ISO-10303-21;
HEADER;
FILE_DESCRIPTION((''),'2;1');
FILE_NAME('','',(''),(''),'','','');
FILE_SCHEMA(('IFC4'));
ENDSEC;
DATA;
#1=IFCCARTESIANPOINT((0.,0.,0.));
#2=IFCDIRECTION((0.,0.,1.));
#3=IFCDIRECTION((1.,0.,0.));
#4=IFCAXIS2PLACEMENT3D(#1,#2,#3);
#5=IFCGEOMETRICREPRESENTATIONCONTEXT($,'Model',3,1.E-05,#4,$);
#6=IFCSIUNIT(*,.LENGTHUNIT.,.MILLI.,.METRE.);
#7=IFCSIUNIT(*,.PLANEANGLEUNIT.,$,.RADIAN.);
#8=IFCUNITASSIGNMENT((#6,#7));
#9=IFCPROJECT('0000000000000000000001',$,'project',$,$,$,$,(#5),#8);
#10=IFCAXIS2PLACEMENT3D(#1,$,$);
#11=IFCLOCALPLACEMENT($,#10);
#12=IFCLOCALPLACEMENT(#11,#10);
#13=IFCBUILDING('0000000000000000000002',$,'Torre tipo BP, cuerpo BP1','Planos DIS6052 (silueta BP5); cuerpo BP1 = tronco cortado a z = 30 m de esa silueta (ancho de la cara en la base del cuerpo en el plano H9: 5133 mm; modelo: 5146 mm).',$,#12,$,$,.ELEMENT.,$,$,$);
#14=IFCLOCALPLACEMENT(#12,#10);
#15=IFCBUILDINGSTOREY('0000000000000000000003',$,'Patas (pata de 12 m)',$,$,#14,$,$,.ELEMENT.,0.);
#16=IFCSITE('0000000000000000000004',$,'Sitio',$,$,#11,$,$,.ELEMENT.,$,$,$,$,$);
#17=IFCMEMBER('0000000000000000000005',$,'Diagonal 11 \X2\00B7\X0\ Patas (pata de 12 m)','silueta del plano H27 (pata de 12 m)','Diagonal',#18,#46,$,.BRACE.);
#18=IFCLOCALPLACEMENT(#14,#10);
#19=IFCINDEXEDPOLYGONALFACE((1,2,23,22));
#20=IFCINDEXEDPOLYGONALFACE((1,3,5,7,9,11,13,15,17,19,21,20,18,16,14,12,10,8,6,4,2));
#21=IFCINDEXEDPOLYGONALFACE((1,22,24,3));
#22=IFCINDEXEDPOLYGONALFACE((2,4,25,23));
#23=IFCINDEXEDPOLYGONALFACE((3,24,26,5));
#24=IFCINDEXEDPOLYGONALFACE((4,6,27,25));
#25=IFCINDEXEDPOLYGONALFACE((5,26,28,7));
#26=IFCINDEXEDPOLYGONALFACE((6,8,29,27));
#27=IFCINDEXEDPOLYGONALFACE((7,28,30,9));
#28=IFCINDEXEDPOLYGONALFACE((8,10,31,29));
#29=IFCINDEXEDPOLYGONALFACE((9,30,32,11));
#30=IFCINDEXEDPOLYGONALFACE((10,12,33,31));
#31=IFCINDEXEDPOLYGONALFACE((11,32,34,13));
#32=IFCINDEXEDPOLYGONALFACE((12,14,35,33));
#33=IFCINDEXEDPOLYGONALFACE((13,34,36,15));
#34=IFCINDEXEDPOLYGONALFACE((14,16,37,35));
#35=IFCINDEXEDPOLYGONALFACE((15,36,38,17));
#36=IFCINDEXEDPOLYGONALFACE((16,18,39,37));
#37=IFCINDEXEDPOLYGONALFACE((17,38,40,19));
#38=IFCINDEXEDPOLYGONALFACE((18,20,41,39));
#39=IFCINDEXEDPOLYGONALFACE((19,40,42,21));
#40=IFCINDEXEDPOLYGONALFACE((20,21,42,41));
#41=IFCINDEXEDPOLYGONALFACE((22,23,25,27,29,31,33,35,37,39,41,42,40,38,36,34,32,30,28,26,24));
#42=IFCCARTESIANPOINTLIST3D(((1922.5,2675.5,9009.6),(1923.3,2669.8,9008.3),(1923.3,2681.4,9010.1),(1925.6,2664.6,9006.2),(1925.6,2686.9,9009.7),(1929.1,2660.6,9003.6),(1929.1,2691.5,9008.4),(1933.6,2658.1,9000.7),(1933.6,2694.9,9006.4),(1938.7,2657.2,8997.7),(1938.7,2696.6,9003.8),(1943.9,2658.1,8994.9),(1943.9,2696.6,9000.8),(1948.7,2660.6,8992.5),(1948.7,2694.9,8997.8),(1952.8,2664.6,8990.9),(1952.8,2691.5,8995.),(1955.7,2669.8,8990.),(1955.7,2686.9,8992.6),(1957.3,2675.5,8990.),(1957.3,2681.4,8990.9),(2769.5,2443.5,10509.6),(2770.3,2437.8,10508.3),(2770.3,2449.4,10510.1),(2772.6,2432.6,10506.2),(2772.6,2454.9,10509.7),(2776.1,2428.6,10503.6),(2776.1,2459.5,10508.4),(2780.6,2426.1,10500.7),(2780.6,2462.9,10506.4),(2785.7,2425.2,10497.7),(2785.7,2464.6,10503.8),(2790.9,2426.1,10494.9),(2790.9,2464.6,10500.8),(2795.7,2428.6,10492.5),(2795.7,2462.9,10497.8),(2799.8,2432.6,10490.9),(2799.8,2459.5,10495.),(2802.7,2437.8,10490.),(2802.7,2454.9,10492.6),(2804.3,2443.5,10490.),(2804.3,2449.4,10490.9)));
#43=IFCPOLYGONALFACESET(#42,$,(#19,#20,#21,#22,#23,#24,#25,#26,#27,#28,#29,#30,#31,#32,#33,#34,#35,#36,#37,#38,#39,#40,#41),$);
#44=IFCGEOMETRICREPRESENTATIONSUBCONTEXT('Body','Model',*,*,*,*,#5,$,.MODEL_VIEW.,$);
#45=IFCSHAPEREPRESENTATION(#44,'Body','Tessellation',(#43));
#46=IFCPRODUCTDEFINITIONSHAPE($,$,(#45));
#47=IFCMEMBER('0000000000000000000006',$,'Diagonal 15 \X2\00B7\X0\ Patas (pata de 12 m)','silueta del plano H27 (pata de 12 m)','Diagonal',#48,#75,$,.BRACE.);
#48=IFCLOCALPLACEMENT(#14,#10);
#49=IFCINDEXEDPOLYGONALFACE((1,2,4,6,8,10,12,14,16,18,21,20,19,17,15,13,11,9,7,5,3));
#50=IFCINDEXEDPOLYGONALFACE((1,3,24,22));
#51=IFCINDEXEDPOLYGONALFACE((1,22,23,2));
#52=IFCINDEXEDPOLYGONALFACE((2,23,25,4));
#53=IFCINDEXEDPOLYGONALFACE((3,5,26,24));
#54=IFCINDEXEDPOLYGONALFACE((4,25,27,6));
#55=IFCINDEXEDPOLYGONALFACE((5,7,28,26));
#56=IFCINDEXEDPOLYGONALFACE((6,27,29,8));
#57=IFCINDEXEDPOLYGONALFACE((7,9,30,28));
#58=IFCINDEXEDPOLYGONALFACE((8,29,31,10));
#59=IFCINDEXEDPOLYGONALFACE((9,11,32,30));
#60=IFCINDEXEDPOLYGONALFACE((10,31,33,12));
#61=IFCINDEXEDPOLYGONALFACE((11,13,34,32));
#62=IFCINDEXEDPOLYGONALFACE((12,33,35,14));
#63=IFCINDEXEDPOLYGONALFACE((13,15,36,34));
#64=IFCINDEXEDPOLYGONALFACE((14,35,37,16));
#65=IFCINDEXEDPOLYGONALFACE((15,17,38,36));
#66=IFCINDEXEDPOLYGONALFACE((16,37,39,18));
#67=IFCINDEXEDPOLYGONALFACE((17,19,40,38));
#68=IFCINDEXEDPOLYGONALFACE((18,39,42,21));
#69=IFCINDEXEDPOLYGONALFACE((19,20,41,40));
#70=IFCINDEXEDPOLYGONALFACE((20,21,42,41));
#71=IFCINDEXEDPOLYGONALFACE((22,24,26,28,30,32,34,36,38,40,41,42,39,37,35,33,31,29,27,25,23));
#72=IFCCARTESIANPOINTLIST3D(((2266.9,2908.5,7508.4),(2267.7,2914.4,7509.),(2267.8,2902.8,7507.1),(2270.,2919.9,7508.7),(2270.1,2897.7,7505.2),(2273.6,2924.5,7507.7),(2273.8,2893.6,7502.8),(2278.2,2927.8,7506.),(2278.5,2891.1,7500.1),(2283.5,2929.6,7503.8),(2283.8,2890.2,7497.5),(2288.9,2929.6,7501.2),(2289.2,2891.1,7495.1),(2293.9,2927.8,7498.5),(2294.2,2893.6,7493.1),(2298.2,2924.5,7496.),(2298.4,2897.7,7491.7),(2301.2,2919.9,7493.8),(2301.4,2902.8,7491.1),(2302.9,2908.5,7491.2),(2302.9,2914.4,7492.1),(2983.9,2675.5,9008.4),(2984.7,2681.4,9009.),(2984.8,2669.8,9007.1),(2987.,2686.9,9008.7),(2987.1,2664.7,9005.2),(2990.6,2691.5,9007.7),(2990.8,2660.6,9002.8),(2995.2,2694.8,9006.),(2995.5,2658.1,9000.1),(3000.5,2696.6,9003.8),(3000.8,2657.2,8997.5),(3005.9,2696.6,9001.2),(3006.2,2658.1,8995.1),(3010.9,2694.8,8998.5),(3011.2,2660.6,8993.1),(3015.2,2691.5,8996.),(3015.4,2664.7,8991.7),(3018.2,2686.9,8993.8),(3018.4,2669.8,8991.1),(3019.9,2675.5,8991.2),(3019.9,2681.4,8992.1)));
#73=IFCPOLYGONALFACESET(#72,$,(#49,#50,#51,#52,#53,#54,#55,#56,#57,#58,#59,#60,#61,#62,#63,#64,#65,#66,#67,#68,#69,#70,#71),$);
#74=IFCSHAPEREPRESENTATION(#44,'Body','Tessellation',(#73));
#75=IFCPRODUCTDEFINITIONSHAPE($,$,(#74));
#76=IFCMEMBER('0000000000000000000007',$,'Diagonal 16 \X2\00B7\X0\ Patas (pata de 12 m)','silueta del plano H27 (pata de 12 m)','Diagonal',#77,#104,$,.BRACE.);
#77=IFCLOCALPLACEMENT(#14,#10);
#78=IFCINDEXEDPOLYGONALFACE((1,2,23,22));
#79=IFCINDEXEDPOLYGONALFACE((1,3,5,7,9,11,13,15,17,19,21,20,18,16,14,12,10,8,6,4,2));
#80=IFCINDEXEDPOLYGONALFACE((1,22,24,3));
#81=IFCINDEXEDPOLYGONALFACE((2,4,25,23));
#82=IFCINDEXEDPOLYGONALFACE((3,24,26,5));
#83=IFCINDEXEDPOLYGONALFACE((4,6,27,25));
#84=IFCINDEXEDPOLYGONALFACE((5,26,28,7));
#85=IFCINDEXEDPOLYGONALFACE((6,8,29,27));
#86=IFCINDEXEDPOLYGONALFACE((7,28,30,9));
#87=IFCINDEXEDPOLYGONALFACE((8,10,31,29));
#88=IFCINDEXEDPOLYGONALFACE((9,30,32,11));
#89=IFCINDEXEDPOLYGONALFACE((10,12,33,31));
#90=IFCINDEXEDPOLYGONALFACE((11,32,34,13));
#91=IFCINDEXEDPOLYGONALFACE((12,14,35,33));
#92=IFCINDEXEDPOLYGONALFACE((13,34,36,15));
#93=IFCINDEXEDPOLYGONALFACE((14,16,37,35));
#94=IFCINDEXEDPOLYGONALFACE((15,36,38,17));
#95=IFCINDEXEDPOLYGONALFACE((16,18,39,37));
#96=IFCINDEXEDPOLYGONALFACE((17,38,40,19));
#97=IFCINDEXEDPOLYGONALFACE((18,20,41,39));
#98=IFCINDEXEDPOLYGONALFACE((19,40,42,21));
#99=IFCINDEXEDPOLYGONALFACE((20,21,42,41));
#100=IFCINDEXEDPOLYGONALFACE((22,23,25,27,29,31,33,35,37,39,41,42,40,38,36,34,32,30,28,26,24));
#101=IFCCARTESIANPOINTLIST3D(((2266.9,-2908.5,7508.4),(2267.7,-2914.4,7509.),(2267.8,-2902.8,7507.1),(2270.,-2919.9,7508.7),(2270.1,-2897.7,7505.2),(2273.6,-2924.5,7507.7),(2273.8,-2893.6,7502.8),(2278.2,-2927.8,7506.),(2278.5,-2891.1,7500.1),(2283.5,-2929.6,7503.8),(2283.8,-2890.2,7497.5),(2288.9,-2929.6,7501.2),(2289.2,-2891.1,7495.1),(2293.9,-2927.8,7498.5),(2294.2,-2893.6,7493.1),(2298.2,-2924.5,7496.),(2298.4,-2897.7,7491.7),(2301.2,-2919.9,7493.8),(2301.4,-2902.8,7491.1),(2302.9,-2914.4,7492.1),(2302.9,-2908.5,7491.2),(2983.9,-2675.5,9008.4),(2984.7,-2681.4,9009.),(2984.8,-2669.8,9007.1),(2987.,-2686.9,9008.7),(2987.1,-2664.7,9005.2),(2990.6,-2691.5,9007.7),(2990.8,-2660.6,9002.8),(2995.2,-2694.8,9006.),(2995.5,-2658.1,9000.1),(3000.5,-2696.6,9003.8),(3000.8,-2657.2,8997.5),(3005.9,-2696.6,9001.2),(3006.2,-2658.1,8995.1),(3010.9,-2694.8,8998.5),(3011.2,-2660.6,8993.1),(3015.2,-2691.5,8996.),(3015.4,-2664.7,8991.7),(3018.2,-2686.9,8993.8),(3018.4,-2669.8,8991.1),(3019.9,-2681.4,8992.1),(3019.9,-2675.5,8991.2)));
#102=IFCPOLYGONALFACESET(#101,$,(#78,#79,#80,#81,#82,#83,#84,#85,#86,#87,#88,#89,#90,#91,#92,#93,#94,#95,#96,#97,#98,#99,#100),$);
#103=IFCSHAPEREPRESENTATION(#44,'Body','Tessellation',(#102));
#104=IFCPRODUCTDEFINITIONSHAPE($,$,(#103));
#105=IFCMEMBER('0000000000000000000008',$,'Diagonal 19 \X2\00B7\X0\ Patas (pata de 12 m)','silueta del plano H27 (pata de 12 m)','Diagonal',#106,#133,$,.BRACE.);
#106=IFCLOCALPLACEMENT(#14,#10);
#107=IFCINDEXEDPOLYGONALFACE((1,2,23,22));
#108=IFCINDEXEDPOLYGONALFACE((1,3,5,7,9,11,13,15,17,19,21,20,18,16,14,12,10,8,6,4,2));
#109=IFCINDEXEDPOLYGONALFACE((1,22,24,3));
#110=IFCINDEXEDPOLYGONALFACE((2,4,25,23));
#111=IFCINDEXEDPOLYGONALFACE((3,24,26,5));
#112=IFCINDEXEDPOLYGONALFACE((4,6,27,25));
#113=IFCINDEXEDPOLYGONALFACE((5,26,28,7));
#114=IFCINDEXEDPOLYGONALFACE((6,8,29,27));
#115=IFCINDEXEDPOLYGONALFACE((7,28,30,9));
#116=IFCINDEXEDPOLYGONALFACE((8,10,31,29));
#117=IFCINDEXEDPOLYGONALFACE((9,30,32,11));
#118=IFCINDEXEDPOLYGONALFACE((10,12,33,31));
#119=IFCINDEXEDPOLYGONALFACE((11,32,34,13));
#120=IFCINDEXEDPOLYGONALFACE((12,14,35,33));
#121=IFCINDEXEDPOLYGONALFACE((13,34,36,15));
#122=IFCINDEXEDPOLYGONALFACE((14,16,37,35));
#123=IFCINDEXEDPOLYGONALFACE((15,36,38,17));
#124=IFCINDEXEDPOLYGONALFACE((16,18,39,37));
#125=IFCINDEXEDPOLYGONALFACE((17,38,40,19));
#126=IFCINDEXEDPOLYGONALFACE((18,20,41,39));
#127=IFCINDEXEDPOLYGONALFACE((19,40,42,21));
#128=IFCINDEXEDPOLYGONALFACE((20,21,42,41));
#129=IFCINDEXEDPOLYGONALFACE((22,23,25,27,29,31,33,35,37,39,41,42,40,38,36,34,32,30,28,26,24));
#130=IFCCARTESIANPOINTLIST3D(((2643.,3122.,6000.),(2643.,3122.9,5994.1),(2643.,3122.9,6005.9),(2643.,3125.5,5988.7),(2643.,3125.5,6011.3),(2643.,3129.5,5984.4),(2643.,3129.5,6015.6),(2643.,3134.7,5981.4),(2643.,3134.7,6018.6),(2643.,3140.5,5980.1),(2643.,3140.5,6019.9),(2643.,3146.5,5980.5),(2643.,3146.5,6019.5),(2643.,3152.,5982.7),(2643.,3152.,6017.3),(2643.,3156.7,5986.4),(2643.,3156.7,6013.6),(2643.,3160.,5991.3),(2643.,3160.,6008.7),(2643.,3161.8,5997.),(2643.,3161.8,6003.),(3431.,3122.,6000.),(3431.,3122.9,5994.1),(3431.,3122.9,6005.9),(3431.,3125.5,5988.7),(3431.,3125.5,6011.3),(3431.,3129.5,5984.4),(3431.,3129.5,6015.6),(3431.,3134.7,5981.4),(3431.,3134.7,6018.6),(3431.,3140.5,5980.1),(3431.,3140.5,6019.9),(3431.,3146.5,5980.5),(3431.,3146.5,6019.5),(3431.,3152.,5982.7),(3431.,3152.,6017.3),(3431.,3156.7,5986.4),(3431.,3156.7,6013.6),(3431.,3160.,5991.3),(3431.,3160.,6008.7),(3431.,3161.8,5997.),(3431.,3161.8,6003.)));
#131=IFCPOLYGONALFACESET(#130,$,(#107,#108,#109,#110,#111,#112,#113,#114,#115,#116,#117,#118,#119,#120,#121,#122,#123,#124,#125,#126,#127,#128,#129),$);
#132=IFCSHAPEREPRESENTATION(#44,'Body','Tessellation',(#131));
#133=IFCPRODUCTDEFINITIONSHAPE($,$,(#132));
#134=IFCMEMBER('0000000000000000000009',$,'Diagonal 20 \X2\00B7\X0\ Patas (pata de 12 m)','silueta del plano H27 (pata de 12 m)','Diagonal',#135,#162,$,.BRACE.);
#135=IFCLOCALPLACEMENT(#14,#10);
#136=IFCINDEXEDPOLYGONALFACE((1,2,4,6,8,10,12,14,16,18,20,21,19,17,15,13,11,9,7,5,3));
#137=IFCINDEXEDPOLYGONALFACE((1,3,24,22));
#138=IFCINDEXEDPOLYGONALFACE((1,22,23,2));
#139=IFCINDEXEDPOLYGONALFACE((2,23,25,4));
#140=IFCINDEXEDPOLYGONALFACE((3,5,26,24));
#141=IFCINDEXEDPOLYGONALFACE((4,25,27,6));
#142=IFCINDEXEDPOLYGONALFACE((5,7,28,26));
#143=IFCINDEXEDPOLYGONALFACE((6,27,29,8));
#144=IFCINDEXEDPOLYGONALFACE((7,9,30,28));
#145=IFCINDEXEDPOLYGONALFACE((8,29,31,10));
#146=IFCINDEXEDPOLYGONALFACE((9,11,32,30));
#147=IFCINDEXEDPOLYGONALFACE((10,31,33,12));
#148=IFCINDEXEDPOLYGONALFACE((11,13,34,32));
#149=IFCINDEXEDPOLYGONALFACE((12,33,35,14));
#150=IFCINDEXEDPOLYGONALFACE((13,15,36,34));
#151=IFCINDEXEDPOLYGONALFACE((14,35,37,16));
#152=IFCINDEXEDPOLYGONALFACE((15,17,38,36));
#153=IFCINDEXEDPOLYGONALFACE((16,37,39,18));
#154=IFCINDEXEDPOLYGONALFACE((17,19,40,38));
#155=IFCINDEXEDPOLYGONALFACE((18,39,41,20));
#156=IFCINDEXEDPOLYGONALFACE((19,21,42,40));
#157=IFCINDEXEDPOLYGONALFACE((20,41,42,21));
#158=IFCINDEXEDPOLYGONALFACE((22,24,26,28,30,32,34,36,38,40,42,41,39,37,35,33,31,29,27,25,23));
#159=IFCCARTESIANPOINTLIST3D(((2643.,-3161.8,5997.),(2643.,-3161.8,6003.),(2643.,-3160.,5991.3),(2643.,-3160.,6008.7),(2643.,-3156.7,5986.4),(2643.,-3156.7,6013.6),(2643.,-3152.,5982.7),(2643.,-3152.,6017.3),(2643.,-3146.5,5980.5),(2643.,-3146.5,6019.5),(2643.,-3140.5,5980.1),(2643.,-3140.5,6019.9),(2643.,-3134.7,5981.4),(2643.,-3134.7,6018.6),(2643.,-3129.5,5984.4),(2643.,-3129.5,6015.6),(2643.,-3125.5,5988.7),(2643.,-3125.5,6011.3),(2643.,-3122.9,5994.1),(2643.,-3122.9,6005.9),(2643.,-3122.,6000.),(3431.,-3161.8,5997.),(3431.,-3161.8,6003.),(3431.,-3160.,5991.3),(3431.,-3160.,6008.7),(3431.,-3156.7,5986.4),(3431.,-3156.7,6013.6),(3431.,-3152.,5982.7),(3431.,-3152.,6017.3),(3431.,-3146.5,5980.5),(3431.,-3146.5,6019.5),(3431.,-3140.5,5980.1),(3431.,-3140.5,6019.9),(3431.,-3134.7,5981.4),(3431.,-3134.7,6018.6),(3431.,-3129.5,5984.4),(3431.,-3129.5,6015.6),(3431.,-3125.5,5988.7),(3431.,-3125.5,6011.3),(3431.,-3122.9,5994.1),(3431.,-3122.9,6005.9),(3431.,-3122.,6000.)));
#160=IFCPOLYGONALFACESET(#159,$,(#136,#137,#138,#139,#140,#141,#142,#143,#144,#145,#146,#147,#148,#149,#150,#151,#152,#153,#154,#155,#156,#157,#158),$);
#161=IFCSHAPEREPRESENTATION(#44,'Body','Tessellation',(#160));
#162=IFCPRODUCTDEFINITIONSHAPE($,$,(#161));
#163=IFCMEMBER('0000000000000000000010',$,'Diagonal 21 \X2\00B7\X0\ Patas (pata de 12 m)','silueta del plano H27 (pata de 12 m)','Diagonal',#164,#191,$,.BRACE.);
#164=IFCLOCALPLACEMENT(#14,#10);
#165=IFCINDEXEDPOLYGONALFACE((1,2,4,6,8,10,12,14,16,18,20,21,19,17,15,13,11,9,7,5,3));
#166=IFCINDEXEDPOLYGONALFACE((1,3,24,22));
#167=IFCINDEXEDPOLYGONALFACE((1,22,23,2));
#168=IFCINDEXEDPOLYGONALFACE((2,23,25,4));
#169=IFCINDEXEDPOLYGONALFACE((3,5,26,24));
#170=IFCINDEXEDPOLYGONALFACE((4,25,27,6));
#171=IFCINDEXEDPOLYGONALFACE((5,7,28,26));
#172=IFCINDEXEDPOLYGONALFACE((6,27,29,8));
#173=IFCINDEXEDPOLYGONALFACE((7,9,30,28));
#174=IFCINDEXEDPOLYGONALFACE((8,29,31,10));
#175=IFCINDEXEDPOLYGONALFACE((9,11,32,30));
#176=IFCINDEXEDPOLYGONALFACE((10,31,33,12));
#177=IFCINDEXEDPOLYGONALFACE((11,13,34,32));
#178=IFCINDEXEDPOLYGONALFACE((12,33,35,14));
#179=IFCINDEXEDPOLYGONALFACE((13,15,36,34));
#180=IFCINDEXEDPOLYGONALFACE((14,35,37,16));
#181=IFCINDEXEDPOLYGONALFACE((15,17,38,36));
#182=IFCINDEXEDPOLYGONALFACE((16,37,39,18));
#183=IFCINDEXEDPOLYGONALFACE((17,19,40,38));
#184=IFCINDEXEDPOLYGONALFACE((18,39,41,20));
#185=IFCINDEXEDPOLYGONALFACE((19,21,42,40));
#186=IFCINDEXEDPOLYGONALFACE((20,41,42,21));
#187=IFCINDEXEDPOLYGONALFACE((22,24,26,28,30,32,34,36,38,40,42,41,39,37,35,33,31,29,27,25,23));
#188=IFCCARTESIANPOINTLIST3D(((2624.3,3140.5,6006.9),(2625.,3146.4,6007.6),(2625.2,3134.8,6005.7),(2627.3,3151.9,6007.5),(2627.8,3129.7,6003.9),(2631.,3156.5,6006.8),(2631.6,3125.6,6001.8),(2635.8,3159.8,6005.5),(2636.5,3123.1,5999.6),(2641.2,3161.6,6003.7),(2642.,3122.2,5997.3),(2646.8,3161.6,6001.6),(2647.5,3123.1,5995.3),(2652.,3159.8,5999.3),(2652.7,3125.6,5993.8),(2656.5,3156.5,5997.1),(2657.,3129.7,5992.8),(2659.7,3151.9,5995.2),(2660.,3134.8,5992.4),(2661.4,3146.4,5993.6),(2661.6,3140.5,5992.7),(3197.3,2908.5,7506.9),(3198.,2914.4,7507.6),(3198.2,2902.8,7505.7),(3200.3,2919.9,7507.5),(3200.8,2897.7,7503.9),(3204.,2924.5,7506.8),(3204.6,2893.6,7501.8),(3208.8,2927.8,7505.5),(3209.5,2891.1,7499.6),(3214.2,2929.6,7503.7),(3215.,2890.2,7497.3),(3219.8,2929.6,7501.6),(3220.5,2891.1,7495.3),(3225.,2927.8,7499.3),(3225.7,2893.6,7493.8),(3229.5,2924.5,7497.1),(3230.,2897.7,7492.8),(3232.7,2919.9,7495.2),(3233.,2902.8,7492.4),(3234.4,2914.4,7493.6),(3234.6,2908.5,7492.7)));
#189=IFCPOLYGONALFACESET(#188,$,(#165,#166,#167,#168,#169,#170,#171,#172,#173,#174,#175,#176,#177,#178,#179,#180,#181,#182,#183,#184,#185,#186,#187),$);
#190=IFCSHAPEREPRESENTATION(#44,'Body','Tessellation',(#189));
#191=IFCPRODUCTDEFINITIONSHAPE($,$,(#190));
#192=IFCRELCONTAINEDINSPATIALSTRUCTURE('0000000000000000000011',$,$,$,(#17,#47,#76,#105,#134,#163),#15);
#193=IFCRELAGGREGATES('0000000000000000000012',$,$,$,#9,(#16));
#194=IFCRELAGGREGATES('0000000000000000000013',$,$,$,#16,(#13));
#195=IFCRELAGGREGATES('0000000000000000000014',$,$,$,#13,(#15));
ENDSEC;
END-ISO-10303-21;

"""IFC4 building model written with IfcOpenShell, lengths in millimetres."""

from ifc_helpers import new_model, si_unit, frame, origin, origin_with_axes, place, context, subcontext, project, spatial, circle, extrude, element, save


model = new_model("IFC4")

# Units and contexts
model_context = context("Model", 3, precision=1e-05, world=origin_with_axes())
body_context = subcontext(model_context, "Body", "Model", "MODEL_VIEW")
ifc_project = project(units=[si_unit("LENGTHUNIT", "METRE", prefix="MILLI"), si_unit("PLANEANGLEUNIT", "RADIAN")], contexts=[model_context])

# Site, building, storey
site_placement = place(None, origin())
site = spatial("IfcSite", under=ifc_project, at=site_placement, Name="Sitio", CompositionType="ELEMENT")
building_placement = place(site_placement, origin())
building = spatial("IfcBuilding", under=site, at=building_placement, Name="Torre tipo BP, cuerpo BP1", Description="Planos DIS6052 (silueta BP5); cuerpo BP1 = tronco cortado a z = 30 m de esa silueta (ancho de la cara en la base del cuerpo en el plano H9: 5133 mm; modelo: 5146 mm).", CompositionType="ELEMENT")
storey_placement = place(building_placement, origin())
storey = spatial("IfcBuildingStorey", under=building, at=storey_placement, Name="Patas (pata de 12 m)", CompositionType="ELEMENT", Elevation=0.0)

# Members
member_1_placement = place(storey_placement, frame((1940.0, 2677.0, 9000.0), z_axis=(0.487294, -0.133474, 0.862977), x_axis=(-0.065628, -0.991052, -0.116225)))
element("IfcMember", 1, at=member_1_placement, inside=storey, Name="Diagonal 11 · Patas (pata de 12 m)", Description="silueta del plano H27 (pata de 12 m)", ObjectType="Diagonal", PredefinedType="BRACE", context=body_context, shape_type="SweptSolid", body=[
    extrude(circle(Radius=20.0), None, (0.0, 0.0, 1.0), 1738.2),
])
for number, where, z_axis, x_axis, name in (
    (2, (2285.0, 2910.0, 7500.0), (0.42709, -0.138789, 0.893494), (-0.059855, -0.990322, -0.125219), "Diagonal 15 · Patas (pata de 12 m)"),
    (3, (2285.0, -2910.0, 7500.0), (0.42709, 0.138789, 0.893494), (-0.059855, 0.990322, -0.125219), "Diagonal 16 · Patas (pata de 12 m)"),
):
    element("IfcMember", number, at=place(storey_placement, frame(where, z_axis=z_axis, x_axis=x_axis)), inside=storey, Name=name, Description="silueta del plano H27 (pata de 12 m)", ObjectType="Diagonal", PredefinedType="BRACE", context=body_context, shape_type="SweptSolid", body=[
        extrude(circle(Radius=20.0), None, (0.0, 0.0, 1.0), 1678.8),
    ])
for number, where, z_axis, x_axis, name in (
    (4, (3431.0, 3142.0, 6000.0), (-1.0, 0.0, 0.0), (0.0, -1.0, 0.0), "Diagonal 19 · Patas (pata de 12 m)"),
    (5, (3431.0, -3142.0, 6000.0), (-1.0, 0.0, 0.0), (0.0, 1.0, 0.0), "Diagonal 20 · Patas (pata de 12 m)"),
):
    element("IfcMember", number, at=place(storey_placement, frame(where, z_axis=z_axis, x_axis=x_axis)), inside=storey, Name=name, Description="silueta del plano H27 (pata de 12 m)", ObjectType="Diagonal", PredefinedType="BRACE", context=body_context, shape_type="SweptSolid", body=[
        extrude(circle(Radius=20.0), None, (0.0, 0.0, 1.0), 788.0),
    ])
for number, where, z_axis, x_axis, name in (
    (6, (2643.0, 3142.0, 6000.0), (0.353182, -0.142999, 0.924561), (-0.051029, -0.989723, -0.133584), "Diagonal 21 · Patas (pata de 12 m)"),
):
    element("IfcMember", number, at=place(storey_placement, frame(where, z_axis=z_axis, x_axis=x_axis)), inside=storey, Name=name, Description="silueta del plano H27 (pata de 12 m)", ObjectType="Diagonal", PredefinedType="BRACE", context=body_context, shape_type="SweptSolid", body=[
        extrude(circle(Radius=20.0), None, (0.0, 0.0, 1.0), 1622.4),
    ])

save(model, "model.ifc")
